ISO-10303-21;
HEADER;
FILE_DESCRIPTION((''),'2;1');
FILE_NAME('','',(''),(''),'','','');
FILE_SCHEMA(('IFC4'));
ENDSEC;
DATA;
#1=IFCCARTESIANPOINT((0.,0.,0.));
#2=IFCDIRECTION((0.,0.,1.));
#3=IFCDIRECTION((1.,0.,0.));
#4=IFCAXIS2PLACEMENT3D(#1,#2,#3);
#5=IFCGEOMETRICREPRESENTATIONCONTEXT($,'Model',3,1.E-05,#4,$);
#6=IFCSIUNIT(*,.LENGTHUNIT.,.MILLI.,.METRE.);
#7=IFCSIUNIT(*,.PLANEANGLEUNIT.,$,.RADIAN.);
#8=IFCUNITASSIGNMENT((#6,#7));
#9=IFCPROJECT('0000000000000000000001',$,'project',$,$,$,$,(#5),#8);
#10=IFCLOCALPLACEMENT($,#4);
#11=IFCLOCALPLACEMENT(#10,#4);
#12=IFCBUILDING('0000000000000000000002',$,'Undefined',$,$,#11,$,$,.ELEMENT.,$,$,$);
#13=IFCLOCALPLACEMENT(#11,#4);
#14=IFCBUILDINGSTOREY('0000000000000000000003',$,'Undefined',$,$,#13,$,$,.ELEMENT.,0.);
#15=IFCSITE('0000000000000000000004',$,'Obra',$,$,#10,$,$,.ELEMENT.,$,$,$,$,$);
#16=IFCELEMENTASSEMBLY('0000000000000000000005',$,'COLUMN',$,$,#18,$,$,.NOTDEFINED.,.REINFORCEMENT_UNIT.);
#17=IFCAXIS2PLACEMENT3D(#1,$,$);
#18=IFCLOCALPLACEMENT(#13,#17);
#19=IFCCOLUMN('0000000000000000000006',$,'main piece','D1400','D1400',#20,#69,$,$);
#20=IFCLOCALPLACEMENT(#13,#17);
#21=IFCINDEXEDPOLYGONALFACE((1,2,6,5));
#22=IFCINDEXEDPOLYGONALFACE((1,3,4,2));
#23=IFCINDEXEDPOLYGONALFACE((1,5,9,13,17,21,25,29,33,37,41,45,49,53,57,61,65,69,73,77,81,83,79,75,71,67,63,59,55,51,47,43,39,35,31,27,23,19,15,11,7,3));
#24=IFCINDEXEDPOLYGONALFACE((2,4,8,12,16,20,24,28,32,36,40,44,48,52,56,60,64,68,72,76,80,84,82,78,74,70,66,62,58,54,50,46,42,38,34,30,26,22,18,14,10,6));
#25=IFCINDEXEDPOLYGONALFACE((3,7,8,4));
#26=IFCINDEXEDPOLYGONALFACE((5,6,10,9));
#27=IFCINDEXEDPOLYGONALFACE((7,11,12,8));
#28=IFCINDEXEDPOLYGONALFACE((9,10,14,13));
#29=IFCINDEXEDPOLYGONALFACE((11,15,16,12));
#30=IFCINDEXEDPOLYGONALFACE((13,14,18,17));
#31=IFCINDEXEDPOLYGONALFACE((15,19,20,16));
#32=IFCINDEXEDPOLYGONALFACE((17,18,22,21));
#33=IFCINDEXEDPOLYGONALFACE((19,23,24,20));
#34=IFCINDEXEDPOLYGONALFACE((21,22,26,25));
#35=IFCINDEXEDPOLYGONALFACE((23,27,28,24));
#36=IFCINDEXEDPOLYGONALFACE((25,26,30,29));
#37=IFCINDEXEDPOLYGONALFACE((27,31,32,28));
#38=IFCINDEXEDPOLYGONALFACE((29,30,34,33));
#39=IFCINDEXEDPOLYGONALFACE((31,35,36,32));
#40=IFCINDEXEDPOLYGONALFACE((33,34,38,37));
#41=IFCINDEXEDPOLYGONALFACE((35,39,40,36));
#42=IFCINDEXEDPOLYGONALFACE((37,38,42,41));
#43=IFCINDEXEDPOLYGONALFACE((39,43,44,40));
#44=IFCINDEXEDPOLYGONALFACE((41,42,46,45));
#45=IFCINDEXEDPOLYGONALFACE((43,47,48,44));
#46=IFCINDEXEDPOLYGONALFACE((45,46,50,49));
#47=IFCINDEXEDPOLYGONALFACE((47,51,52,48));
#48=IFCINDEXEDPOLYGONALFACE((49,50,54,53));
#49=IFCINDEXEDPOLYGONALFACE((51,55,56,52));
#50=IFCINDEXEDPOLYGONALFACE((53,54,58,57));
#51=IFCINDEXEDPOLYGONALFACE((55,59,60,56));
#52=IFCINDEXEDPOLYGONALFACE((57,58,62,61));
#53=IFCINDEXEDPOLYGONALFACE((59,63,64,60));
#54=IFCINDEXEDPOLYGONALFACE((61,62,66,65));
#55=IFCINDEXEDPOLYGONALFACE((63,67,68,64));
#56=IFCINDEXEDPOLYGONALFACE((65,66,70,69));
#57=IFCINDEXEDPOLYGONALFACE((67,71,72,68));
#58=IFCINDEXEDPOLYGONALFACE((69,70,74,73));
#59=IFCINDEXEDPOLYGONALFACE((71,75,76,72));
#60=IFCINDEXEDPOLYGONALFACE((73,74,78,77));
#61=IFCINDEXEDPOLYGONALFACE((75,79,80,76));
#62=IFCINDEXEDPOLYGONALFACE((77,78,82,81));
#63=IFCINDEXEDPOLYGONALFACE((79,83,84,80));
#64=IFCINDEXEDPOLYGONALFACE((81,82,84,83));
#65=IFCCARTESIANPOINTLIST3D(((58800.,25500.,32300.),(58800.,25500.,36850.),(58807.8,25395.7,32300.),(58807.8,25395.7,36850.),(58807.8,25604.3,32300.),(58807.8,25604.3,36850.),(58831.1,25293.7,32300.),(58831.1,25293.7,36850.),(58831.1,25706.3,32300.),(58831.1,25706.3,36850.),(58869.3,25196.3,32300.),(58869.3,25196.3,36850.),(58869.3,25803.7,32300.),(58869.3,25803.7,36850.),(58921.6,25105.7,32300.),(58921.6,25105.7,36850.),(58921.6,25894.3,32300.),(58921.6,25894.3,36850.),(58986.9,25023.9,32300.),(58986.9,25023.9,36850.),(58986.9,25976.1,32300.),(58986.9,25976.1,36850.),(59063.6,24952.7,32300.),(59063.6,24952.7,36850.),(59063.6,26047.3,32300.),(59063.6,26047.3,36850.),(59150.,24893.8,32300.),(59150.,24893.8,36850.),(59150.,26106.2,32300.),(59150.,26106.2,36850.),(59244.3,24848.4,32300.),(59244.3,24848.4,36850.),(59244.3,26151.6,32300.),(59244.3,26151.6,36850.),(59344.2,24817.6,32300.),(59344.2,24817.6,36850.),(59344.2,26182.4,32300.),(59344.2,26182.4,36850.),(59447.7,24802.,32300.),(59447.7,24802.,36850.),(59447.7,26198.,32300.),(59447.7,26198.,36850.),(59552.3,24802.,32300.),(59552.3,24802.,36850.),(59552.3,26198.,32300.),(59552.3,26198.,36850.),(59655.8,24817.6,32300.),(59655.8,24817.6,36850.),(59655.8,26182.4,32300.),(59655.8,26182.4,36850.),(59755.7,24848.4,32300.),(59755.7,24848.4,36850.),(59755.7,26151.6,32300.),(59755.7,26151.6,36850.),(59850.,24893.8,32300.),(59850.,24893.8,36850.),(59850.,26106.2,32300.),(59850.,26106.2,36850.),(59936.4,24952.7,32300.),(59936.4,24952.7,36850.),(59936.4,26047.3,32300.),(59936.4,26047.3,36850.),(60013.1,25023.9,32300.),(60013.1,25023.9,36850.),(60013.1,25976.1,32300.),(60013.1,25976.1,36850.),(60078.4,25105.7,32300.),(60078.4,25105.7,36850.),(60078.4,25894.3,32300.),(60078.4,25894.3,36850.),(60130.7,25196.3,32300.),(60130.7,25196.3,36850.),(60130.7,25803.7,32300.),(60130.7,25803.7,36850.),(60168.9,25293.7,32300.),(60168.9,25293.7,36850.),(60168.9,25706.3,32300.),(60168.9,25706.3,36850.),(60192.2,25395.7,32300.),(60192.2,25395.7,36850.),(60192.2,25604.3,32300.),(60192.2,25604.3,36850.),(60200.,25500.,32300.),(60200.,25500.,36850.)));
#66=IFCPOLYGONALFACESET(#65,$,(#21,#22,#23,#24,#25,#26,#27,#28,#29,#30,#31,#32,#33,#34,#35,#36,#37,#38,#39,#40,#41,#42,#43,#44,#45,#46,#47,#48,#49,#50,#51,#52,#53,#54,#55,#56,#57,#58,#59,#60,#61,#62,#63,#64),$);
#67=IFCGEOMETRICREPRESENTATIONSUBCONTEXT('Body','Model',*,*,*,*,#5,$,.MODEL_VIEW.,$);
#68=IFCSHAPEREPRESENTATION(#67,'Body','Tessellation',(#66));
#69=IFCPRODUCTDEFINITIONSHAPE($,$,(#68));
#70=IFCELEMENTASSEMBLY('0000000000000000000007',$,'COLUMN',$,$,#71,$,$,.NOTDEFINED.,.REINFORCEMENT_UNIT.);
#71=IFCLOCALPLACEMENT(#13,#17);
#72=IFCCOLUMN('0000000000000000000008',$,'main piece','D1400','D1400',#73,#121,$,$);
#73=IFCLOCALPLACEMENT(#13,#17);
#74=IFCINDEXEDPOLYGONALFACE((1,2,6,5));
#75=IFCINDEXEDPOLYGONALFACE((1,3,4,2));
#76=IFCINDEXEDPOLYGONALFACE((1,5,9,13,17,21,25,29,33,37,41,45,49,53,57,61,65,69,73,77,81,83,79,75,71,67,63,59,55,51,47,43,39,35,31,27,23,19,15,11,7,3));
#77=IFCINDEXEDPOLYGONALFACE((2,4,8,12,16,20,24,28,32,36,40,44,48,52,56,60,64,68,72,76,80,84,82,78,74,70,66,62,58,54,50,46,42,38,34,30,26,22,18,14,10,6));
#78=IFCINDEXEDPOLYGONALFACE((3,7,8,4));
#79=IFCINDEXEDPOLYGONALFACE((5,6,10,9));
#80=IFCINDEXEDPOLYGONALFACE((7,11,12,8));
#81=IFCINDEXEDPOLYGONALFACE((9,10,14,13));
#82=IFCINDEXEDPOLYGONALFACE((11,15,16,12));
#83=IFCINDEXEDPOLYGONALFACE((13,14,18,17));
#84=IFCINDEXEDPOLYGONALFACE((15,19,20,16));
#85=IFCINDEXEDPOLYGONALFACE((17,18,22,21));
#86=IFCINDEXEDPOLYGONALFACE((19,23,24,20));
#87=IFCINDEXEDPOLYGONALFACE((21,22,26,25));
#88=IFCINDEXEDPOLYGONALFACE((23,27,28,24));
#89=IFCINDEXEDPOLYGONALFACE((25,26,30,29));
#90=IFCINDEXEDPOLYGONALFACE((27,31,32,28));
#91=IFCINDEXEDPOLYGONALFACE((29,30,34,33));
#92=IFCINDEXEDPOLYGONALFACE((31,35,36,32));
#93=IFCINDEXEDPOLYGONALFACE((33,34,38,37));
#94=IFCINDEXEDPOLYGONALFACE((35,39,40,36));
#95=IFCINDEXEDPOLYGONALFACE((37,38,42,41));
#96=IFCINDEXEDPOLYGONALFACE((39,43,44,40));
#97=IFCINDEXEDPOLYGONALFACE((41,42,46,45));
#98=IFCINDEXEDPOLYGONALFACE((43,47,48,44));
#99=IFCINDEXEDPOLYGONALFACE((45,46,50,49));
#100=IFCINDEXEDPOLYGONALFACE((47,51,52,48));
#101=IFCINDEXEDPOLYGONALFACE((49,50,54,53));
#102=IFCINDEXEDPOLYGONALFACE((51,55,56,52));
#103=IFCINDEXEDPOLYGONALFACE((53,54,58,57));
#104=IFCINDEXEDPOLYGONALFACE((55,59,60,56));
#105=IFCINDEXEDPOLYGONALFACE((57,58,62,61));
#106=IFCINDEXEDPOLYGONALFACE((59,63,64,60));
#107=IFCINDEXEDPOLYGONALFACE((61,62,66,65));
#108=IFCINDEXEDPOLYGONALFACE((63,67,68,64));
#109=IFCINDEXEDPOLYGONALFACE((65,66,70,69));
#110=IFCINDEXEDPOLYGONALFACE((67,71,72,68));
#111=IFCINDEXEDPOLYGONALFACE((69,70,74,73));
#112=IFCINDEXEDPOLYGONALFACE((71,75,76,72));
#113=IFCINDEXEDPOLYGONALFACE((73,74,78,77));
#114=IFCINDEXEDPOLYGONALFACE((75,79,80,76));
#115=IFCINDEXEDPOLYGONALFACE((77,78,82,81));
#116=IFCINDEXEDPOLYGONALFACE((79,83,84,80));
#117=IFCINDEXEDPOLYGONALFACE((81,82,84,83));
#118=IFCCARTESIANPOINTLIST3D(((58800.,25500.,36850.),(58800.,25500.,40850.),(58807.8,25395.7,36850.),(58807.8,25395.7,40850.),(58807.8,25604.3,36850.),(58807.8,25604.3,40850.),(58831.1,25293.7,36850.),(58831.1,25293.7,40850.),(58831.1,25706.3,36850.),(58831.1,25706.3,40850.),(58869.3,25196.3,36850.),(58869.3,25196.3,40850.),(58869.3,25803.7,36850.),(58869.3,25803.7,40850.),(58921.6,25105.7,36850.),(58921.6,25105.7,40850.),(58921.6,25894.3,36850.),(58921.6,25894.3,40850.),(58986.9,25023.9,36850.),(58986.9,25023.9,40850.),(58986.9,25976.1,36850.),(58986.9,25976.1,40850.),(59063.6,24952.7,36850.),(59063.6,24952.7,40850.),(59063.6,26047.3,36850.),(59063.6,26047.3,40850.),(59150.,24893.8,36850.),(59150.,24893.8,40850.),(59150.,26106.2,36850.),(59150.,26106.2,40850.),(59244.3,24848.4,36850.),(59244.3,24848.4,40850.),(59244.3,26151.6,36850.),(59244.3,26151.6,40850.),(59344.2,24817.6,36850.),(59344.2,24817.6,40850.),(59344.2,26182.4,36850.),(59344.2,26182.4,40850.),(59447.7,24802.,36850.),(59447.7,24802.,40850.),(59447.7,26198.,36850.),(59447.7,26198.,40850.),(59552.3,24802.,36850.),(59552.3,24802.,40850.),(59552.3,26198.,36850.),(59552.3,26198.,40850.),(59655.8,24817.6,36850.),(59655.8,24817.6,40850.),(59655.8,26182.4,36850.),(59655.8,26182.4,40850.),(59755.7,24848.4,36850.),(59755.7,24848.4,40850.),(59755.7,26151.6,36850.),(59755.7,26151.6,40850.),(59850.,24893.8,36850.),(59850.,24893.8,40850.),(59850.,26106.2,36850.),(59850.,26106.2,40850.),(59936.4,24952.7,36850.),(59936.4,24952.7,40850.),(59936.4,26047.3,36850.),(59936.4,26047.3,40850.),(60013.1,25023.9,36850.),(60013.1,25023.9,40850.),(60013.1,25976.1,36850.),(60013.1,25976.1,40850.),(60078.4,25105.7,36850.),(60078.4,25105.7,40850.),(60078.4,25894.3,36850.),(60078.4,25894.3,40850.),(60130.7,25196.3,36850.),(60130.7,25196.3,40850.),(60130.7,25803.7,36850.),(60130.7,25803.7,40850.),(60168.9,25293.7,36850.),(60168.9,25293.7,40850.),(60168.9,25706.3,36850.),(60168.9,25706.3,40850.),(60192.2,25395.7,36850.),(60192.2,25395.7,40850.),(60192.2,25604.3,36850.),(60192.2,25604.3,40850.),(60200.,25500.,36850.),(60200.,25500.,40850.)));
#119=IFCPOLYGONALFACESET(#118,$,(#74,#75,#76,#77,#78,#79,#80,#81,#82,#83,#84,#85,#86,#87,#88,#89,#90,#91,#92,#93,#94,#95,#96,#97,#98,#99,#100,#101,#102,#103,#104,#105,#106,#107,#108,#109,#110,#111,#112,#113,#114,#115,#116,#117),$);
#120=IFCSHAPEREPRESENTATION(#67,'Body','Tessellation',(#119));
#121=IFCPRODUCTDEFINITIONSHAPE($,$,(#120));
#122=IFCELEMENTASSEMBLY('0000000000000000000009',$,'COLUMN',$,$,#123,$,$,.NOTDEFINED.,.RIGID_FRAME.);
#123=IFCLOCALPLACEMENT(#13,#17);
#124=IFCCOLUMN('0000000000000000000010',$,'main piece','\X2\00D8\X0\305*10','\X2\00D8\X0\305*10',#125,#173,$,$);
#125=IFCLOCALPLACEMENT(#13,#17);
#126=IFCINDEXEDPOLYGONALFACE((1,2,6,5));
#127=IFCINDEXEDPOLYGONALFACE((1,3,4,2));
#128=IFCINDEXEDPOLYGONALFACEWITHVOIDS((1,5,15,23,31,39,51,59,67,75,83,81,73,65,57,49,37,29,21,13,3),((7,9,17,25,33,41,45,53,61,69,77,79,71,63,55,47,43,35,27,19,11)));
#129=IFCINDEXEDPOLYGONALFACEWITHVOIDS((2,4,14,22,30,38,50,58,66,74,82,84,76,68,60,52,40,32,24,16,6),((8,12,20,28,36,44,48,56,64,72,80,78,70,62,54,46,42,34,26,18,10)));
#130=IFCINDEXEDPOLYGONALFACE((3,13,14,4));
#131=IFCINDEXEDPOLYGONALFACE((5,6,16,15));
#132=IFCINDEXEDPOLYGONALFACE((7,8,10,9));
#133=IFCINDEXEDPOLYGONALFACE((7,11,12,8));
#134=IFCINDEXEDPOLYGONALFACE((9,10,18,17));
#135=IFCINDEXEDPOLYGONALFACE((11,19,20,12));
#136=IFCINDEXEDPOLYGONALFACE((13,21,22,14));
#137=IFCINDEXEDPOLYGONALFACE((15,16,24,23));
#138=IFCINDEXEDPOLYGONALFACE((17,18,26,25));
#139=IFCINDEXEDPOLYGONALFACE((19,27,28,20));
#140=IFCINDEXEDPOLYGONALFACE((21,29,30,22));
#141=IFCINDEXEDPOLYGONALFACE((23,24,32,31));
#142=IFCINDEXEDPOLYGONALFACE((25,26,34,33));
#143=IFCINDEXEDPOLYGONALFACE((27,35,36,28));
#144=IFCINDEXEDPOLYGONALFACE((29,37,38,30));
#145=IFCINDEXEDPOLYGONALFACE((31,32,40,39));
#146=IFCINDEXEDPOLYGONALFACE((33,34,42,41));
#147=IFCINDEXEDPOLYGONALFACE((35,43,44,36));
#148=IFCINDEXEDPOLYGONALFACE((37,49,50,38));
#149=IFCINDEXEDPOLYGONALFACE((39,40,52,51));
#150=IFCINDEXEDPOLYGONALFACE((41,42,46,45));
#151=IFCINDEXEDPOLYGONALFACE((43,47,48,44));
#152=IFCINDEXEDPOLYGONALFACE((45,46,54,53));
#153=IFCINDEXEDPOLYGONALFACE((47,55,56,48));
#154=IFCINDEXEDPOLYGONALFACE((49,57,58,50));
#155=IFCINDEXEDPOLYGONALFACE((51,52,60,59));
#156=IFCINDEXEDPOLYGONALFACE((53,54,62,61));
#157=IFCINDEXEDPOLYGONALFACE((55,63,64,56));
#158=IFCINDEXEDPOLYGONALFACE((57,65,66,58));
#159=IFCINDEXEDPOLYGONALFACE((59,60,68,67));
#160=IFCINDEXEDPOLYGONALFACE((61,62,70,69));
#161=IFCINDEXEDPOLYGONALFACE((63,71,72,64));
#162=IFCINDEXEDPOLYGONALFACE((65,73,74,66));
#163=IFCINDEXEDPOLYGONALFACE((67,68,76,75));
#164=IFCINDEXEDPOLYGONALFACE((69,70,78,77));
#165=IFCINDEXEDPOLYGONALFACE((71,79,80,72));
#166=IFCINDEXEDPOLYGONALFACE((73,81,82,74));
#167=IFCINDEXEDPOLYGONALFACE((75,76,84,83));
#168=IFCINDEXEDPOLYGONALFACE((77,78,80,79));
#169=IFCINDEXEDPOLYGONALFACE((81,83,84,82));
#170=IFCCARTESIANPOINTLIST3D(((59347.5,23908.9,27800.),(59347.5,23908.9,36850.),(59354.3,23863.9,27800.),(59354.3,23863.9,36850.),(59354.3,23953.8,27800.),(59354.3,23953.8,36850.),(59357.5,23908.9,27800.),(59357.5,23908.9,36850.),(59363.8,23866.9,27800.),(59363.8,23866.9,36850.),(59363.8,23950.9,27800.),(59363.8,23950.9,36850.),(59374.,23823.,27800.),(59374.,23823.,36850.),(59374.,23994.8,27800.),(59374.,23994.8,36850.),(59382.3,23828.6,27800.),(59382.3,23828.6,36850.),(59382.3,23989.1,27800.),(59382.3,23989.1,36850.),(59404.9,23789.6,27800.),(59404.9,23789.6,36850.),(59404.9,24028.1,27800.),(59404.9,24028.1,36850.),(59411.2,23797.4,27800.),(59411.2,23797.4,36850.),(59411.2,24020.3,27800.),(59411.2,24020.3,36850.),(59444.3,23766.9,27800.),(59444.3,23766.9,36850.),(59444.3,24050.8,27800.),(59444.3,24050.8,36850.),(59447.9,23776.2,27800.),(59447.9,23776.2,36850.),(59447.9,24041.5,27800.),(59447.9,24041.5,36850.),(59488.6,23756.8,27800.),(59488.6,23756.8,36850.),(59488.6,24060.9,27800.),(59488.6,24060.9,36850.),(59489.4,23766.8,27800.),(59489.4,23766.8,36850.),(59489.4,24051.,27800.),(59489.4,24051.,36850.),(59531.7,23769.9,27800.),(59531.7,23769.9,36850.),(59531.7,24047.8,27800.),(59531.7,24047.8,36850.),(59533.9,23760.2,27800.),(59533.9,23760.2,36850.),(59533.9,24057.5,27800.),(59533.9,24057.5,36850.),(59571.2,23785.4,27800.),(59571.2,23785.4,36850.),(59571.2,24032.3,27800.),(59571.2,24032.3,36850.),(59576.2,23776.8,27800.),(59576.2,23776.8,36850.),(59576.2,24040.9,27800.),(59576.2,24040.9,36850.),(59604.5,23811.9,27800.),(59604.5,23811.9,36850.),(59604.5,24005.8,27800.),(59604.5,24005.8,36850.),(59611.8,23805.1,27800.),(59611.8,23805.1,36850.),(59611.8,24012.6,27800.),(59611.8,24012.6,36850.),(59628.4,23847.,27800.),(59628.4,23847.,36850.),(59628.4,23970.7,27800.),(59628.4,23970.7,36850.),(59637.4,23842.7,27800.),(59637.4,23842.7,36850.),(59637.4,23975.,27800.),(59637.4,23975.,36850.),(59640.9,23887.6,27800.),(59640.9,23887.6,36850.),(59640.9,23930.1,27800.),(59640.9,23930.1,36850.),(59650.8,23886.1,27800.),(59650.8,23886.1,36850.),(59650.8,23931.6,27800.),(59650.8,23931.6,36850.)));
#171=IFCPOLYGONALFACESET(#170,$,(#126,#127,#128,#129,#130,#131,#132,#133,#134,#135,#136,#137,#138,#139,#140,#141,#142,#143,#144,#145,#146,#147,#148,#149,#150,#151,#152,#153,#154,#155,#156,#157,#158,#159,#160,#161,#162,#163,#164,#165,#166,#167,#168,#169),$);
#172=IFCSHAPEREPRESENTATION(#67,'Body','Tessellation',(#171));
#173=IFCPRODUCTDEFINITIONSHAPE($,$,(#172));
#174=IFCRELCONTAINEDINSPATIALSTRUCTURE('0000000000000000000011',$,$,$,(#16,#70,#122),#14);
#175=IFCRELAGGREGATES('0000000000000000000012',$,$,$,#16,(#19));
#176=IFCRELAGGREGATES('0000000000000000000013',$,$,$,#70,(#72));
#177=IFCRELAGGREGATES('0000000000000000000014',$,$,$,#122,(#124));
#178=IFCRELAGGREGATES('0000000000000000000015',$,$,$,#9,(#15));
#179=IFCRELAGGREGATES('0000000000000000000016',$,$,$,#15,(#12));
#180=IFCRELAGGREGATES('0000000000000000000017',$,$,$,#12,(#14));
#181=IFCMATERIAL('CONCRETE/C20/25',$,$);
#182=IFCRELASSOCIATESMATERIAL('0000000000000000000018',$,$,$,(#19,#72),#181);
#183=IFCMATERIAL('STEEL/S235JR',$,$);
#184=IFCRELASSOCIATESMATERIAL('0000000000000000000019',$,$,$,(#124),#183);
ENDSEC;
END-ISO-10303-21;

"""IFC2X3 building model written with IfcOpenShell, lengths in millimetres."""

from ifc_helpers import new_model, si_unit, frame, origin_with_axes, origin_2d_with_axis, place, context, subcontext, project, spatial, circle, hollow_circle, extrude, material, element, aggregate, save


model = new_model("IFC2X3")

# Units and contexts
model_context = context("Model", 3, precision=1e-05, world=origin_with_axes())
body_context = subcontext(model_context, "Body", "Model", "MODEL_VIEW")
ifc_project = project(units=[si_unit("LENGTHUNIT", "METRE", prefix="MILLI"), si_unit("PLANEANGLEUNIT", "RADIAN")], contexts=[model_context])

# Site, building, storey
site_placement = place(None, origin_with_axes())
site = spatial("IfcSite", under=ifc_project, at=site_placement, Name="Obra", CompositionType="ELEMENT")
building_placement = place(site_placement, origin_with_axes())
building = spatial("IfcBuilding", under=site, at=building_placement, Name="Undefined", CompositionType="ELEMENT")
storey_placement = place(building_placement, origin_with_axes())
storey = spatial("IfcBuildingStorey", under=building, at=storey_placement, Name="Undefined", CompositionType="ELEMENT", Elevation=0.0)

# Element assemblies, columns
assembly_1_placement = place(storey_placement, origin_with_axes())
assembly_1 = element("IfcElementAssembly", 1, at=assembly_1_placement, inside=storey, Name="COLUMN", AssemblyPlace="NOTDEFINED", PredefinedType="REINFORCEMENT_UNIT")
ifc_material_1 = material(Name="CONCRETE/C20/25")
column_1_placement = place(assembly_1_placement, frame((59500.0, 25500.0, 32300.0), z_axis=(0.0, 0.0, 1.0), x_axis=(0.0, 1.0, 0.0)))
column_1 = element("IfcColumn", 2, at=column_1_placement, material=ifc_material_1, Name="main piece", Description="D1400", ObjectType="D1400", context=body_context, shape_type="SweptSolid", body=[
    extrude(circle(Radius=700.0, at=origin_2d_with_axis()), frame((0.0, 0.0, 4550.0), z_axis=(0.0, 0.0, -1.0), x_axis=(0.0, 1.0, 0.0)), (0.0, 0.0, 1.0), 4550.0),
])
aggregate(assembly_1, [column_1])
assembly_2_placement = place(storey_placement, origin_with_axes())
assembly_2 = element("IfcElementAssembly", 3, at=assembly_2_placement, inside=storey, Name="COLUMN", AssemblyPlace="NOTDEFINED", PredefinedType="REINFORCEMENT_UNIT")
column_2_placement = place(assembly_2_placement, frame((59500.0, 25500.0, 36850.0), z_axis=(0.0, 0.0, 1.0), x_axis=(0.0, 1.0, 0.0)))
column_2 = element("IfcColumn", 4, at=column_2_placement, material=ifc_material_1, Name="main piece", Description="D1400", ObjectType="D1400", context=body_context, shape_type="SweptSolid", body=[
    extrude(circle(Radius=700.0, at=origin_2d_with_axis()), frame((0.0, 0.0, 4000.0), z_axis=(0.0, 0.0, -1.0), x_axis=(0.0, 1.0, 0.0)), (0.0, 0.0, 1.0), 4000.0),
])
aggregate(assembly_2, [column_2])
assembly_3_placement = place(storey_placement, origin_with_axes())
assembly_3 = element("IfcElementAssembly", 5, at=assembly_3_placement, inside=storey, Name="COLUMN", AssemblyPlace="NOTDEFINED", PredefinedType="RIGID_FRAME")
ifc_material_2 = material(Name="STEEL/S235JR")
column_3_placement = place(assembly_3_placement, frame((59500.0, 23908.9, 27800.0), z_axis=(0.0, 0.0, 1.0), x_axis=(0.0, 1.0, 0.0)))
column_3 = element("IfcColumn", 6, at=column_3_placement, material=ifc_material_2, Name="main piece", Description="Ø305*10", ObjectType="Ø305*10", context=body_context, shape_type="SweptSolid", body=[
    extrude(hollow_circle(Radius=152.5, WallThickness=10.0, at=origin_2d_with_axis()), frame((0.0, 0.0, 9050.0), z_axis=(0.0, 0.0, -1.0), x_axis=(0.0, 1.0, 0.0)), (0.0, 0.0, 1.0), 9050.0),
])

aggregate(assembly_3, [column_3])

save(model, "model.ifc")
